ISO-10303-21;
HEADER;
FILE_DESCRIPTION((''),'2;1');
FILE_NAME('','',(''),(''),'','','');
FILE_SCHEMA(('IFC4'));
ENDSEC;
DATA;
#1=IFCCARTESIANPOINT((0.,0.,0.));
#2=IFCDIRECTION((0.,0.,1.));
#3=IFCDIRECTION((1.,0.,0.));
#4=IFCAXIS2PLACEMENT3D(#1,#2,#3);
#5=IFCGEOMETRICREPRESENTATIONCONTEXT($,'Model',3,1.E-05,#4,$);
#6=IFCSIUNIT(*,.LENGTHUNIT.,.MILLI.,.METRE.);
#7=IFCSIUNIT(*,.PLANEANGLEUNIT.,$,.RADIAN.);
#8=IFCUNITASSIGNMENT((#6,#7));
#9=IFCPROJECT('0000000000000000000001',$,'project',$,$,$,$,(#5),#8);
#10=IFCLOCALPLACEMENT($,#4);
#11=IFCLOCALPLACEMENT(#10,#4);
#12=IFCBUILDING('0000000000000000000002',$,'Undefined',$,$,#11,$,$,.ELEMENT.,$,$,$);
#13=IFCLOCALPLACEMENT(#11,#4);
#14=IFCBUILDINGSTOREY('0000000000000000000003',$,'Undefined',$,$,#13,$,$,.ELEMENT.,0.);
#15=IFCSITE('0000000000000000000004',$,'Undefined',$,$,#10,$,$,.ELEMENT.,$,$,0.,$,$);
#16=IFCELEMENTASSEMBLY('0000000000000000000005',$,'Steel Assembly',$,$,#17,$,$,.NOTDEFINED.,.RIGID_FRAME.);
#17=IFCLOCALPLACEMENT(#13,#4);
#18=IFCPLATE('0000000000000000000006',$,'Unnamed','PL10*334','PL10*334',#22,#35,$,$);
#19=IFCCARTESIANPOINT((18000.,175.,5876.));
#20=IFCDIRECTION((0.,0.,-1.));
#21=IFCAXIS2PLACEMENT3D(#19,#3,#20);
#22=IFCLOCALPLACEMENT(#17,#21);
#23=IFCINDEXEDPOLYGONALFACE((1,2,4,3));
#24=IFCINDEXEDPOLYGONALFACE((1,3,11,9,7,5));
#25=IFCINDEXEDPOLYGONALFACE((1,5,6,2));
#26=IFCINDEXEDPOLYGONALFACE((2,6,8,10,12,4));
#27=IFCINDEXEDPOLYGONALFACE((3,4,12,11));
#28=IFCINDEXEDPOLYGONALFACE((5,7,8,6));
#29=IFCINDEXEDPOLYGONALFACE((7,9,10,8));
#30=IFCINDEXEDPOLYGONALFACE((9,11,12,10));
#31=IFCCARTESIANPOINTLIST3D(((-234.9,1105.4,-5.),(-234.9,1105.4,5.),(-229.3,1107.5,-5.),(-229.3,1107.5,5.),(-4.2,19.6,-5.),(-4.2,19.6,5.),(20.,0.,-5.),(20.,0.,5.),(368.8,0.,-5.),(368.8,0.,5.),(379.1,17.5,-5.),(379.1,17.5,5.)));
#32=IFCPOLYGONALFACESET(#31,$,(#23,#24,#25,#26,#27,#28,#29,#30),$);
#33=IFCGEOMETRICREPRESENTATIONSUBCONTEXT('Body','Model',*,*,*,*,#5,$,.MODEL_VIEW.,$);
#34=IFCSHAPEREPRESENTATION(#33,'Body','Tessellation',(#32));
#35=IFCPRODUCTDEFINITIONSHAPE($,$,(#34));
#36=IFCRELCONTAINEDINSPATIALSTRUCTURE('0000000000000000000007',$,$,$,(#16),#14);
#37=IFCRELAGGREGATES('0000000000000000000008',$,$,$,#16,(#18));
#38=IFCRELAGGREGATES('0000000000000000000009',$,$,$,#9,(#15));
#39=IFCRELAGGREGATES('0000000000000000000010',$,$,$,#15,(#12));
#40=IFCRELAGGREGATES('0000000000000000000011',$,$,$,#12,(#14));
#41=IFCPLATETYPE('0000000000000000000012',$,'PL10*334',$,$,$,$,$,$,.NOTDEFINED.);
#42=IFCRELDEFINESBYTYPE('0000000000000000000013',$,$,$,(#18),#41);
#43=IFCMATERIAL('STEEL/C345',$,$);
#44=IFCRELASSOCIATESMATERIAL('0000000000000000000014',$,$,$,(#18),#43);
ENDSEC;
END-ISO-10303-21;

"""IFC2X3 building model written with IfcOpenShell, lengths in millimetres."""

from ifc_helpers import new_model, si_unit, frame, origin_with_axes, place, context, subcontext, project, spatial, polyline, outline, extrude, material, type_object, element, aggregate, save


model = new_model("IFC2X3")

# Units and contexts
model_context = context("Model", 3, precision=1e-05, world=origin_with_axes())
body_context = subcontext(model_context, "Body", "Model", "MODEL_VIEW")
ifc_project = project(units=[si_unit("LENGTHUNIT", "METRE", prefix="MILLI"), si_unit("PLANEANGLEUNIT", "RADIAN")], contexts=[model_context])

# Site, building, storey
site_placement = place(None, origin_with_axes())
site = spatial("IfcSite", under=ifc_project, at=site_placement, Name="Undefined", CompositionType="ELEMENT", RefElevation=0.0)
building_placement = place(site_placement, origin_with_axes())
building = spatial("IfcBuilding", under=site, at=building_placement, Name="Undefined", CompositionType="ELEMENT")
storey_placement = place(building_placement, origin_with_axes())
storey = spatial("IfcBuildingStorey", under=building, at=storey_placement, Name="Undefined", CompositionType="ELEMENT", Elevation=0.0)

# Shared definitions
ifc_material = material(Name="STEEL/C345")

# Element assembly, plate
assembly_1_placement = place(storey_placement, origin_with_axes())
assembly_1 = element("IfcElementAssembly", 1, at=assembly_1_placement, inside=storey, Name="Steel Assembly", AssemblyPlace="NOTDEFINED", PredefinedType="RIGID_FRAME")
plate_type_1 = type_object("IfcPlateType", Name="PL10*334", PredefinedType="NOTDEFINED")
plate_1_placement = place(assembly_1_placement, frame((18000.0, 175.0, 5876.0), z_axis=(1.0, 0.0, 0.0), x_axis=(0.0, 0.0, -1.0)))
plate_1 = element("IfcPlate", 2, at=plate_1_placement, type_object=plate_type_1, material=ifc_material, Name="Unnamed", Description="PL10*334", ObjectType="PL10*334", context=body_context, shape_type="SweptSolid", body=[
    extrude(outline(polyline([(-4.2, 19.6), (20.0, 0.0), (368.8, 0.0), (379.1, 17.5), (-229.3, 1107.5), (-234.9, 1105.4), (-4.2, 19.6)])), frame((0.0, 0.0, -5.0), z_axis=(0.0, 0.0, 1.0), x_axis=(1.0, 0.0, 0.0)), (0.0, 0.0, 1.0), 10.0),
])
aggregate(assembly_1, [plate_1])

save(model, "model.ifc")
